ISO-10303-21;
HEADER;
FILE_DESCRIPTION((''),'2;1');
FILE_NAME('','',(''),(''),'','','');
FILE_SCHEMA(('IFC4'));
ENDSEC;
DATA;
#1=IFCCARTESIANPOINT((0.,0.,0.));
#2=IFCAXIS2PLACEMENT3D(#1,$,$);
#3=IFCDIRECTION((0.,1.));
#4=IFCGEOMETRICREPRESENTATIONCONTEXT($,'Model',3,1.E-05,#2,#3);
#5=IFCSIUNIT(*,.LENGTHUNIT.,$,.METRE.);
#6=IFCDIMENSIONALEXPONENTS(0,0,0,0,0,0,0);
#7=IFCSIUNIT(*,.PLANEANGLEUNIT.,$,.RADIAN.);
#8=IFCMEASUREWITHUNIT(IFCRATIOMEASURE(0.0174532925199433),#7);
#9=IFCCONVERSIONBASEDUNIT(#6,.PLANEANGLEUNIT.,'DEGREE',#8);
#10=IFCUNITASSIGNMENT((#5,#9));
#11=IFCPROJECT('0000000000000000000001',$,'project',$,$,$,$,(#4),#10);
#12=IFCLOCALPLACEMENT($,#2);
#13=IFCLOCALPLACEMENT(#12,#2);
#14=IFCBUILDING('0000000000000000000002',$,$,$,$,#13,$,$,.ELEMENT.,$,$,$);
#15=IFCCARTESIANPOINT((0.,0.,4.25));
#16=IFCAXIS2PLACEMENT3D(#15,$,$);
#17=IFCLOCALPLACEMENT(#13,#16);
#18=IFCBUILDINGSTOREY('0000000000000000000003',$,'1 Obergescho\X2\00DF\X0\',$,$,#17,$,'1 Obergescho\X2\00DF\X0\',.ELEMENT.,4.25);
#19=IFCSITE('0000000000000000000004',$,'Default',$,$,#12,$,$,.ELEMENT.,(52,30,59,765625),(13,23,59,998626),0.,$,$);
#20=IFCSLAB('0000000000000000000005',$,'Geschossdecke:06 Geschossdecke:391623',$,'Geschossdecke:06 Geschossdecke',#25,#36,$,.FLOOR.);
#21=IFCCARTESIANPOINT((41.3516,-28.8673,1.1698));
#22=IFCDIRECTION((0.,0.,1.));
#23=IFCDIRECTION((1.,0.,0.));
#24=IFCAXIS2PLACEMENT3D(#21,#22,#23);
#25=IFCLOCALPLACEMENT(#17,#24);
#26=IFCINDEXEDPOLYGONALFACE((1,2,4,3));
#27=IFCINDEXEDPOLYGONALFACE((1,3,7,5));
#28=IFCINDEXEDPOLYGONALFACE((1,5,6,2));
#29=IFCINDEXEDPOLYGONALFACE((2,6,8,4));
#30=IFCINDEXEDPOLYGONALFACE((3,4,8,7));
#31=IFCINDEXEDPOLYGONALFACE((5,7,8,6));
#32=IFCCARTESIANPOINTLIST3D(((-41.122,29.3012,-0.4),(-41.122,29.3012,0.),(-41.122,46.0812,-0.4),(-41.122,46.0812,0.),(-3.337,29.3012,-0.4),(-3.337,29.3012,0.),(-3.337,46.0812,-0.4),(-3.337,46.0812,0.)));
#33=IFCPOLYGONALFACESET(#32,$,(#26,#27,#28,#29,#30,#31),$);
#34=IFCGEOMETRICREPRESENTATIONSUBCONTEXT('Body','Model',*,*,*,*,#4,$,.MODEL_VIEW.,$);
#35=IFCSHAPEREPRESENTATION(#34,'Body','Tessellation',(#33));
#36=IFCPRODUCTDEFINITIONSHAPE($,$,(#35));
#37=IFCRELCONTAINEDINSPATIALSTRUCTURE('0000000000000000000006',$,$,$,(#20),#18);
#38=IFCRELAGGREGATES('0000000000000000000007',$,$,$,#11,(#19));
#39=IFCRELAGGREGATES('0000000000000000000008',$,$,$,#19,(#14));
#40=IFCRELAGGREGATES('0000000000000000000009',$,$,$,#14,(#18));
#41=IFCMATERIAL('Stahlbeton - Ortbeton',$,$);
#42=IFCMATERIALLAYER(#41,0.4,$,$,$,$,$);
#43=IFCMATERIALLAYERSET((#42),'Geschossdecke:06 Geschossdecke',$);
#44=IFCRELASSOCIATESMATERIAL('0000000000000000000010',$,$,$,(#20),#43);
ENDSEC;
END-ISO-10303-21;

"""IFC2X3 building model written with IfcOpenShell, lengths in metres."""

from ifc_helpers import new_model, entity, si_unit, converted_unit, direction, frame, frame_2d, origin, place, context, subcontext, project, spatial, rectangle, extrude, material, layer, layer_set, layer_usage, element, save


model = new_model("IFC2X3")

# Units and contexts
model_context = context("Model", 3, precision=1e-05, world=origin(), true_north=direction((0.0, 1.0)))
body_context = subcontext(model_context, "Body", "Model", "MODEL_VIEW")
ifc_project = project(units=[si_unit("LENGTHUNIT", "METRE"), converted_unit("PLANEANGLEUNIT", "DEGREE", entity("IfcRatioMeasure", 0.0174532925199433), si_unit("PLANEANGLEUNIT", "RADIAN"), dimensions=[0, 0, 0, 0, 0, 0, 0])], contexts=[model_context])

# Site, building, storey
site_placement = place(None, origin())
site = spatial("IfcSite", under=ifc_project, at=site_placement, Name="Default", CompositionType="ELEMENT", RefLatitude=(52, 30, 59, 765625), RefLongitude=(13, 23, 59, 998626), RefElevation=0.0)
building_placement = place(site_placement, origin())
building = spatial("IfcBuilding", under=site, at=building_placement, CompositionType="ELEMENT")
storey_placement = place(building_placement, frame((0.0, 0.0, 4.25)))
storey = spatial("IfcBuildingStorey", under=building, at=storey_placement, Name="1 Obergeschoß", LongName="1 Obergeschoß", CompositionType="ELEMENT", Elevation=4.25)

# Slab
ifc_material_1 = material(Name="Stahlbeton - Ortbeton")
ifc_layer_1 = layer(ifc_material_1, 0.4)
ifc_layer_set_1 = layer_set([ifc_layer_1], Name="Geschossdecke:06 Geschossdecke")
ifc_layer_usage_1 = layer_usage(ifc_layer_set_1, "AXIS3", "POSITIVE", 0.0)
slab_placement = place(storey_placement, frame((41.3516, -28.8673, 1.1698), z_axis=(0.0, 0.0, 1.0), x_axis=(1.0, 0.0, 0.0)))
element("IfcSlab", 1, at=slab_placement, inside=storey, material=ifc_layer_usage_1, Name="Geschossdecke:06 Geschossdecke:391623", ObjectType="Geschossdecke:06 Geschossdecke", PredefinedType="FLOOR", context=body_context, shape_type="SweptSolid", body=[
    extrude(rectangle(XDim=16.78, YDim=37.785, at=frame_2d((0.0, 0.0), x_axis=(1.0, 0.0))), frame((-22.2295, 37.6912, 0.0), z_axis=(0.0, 0.0, -1.0), x_axis=(0.0, 1.0, 0.0)), (0.0, 0.0, 1.0), 0.4),
])

save(model, "model.ifc")
